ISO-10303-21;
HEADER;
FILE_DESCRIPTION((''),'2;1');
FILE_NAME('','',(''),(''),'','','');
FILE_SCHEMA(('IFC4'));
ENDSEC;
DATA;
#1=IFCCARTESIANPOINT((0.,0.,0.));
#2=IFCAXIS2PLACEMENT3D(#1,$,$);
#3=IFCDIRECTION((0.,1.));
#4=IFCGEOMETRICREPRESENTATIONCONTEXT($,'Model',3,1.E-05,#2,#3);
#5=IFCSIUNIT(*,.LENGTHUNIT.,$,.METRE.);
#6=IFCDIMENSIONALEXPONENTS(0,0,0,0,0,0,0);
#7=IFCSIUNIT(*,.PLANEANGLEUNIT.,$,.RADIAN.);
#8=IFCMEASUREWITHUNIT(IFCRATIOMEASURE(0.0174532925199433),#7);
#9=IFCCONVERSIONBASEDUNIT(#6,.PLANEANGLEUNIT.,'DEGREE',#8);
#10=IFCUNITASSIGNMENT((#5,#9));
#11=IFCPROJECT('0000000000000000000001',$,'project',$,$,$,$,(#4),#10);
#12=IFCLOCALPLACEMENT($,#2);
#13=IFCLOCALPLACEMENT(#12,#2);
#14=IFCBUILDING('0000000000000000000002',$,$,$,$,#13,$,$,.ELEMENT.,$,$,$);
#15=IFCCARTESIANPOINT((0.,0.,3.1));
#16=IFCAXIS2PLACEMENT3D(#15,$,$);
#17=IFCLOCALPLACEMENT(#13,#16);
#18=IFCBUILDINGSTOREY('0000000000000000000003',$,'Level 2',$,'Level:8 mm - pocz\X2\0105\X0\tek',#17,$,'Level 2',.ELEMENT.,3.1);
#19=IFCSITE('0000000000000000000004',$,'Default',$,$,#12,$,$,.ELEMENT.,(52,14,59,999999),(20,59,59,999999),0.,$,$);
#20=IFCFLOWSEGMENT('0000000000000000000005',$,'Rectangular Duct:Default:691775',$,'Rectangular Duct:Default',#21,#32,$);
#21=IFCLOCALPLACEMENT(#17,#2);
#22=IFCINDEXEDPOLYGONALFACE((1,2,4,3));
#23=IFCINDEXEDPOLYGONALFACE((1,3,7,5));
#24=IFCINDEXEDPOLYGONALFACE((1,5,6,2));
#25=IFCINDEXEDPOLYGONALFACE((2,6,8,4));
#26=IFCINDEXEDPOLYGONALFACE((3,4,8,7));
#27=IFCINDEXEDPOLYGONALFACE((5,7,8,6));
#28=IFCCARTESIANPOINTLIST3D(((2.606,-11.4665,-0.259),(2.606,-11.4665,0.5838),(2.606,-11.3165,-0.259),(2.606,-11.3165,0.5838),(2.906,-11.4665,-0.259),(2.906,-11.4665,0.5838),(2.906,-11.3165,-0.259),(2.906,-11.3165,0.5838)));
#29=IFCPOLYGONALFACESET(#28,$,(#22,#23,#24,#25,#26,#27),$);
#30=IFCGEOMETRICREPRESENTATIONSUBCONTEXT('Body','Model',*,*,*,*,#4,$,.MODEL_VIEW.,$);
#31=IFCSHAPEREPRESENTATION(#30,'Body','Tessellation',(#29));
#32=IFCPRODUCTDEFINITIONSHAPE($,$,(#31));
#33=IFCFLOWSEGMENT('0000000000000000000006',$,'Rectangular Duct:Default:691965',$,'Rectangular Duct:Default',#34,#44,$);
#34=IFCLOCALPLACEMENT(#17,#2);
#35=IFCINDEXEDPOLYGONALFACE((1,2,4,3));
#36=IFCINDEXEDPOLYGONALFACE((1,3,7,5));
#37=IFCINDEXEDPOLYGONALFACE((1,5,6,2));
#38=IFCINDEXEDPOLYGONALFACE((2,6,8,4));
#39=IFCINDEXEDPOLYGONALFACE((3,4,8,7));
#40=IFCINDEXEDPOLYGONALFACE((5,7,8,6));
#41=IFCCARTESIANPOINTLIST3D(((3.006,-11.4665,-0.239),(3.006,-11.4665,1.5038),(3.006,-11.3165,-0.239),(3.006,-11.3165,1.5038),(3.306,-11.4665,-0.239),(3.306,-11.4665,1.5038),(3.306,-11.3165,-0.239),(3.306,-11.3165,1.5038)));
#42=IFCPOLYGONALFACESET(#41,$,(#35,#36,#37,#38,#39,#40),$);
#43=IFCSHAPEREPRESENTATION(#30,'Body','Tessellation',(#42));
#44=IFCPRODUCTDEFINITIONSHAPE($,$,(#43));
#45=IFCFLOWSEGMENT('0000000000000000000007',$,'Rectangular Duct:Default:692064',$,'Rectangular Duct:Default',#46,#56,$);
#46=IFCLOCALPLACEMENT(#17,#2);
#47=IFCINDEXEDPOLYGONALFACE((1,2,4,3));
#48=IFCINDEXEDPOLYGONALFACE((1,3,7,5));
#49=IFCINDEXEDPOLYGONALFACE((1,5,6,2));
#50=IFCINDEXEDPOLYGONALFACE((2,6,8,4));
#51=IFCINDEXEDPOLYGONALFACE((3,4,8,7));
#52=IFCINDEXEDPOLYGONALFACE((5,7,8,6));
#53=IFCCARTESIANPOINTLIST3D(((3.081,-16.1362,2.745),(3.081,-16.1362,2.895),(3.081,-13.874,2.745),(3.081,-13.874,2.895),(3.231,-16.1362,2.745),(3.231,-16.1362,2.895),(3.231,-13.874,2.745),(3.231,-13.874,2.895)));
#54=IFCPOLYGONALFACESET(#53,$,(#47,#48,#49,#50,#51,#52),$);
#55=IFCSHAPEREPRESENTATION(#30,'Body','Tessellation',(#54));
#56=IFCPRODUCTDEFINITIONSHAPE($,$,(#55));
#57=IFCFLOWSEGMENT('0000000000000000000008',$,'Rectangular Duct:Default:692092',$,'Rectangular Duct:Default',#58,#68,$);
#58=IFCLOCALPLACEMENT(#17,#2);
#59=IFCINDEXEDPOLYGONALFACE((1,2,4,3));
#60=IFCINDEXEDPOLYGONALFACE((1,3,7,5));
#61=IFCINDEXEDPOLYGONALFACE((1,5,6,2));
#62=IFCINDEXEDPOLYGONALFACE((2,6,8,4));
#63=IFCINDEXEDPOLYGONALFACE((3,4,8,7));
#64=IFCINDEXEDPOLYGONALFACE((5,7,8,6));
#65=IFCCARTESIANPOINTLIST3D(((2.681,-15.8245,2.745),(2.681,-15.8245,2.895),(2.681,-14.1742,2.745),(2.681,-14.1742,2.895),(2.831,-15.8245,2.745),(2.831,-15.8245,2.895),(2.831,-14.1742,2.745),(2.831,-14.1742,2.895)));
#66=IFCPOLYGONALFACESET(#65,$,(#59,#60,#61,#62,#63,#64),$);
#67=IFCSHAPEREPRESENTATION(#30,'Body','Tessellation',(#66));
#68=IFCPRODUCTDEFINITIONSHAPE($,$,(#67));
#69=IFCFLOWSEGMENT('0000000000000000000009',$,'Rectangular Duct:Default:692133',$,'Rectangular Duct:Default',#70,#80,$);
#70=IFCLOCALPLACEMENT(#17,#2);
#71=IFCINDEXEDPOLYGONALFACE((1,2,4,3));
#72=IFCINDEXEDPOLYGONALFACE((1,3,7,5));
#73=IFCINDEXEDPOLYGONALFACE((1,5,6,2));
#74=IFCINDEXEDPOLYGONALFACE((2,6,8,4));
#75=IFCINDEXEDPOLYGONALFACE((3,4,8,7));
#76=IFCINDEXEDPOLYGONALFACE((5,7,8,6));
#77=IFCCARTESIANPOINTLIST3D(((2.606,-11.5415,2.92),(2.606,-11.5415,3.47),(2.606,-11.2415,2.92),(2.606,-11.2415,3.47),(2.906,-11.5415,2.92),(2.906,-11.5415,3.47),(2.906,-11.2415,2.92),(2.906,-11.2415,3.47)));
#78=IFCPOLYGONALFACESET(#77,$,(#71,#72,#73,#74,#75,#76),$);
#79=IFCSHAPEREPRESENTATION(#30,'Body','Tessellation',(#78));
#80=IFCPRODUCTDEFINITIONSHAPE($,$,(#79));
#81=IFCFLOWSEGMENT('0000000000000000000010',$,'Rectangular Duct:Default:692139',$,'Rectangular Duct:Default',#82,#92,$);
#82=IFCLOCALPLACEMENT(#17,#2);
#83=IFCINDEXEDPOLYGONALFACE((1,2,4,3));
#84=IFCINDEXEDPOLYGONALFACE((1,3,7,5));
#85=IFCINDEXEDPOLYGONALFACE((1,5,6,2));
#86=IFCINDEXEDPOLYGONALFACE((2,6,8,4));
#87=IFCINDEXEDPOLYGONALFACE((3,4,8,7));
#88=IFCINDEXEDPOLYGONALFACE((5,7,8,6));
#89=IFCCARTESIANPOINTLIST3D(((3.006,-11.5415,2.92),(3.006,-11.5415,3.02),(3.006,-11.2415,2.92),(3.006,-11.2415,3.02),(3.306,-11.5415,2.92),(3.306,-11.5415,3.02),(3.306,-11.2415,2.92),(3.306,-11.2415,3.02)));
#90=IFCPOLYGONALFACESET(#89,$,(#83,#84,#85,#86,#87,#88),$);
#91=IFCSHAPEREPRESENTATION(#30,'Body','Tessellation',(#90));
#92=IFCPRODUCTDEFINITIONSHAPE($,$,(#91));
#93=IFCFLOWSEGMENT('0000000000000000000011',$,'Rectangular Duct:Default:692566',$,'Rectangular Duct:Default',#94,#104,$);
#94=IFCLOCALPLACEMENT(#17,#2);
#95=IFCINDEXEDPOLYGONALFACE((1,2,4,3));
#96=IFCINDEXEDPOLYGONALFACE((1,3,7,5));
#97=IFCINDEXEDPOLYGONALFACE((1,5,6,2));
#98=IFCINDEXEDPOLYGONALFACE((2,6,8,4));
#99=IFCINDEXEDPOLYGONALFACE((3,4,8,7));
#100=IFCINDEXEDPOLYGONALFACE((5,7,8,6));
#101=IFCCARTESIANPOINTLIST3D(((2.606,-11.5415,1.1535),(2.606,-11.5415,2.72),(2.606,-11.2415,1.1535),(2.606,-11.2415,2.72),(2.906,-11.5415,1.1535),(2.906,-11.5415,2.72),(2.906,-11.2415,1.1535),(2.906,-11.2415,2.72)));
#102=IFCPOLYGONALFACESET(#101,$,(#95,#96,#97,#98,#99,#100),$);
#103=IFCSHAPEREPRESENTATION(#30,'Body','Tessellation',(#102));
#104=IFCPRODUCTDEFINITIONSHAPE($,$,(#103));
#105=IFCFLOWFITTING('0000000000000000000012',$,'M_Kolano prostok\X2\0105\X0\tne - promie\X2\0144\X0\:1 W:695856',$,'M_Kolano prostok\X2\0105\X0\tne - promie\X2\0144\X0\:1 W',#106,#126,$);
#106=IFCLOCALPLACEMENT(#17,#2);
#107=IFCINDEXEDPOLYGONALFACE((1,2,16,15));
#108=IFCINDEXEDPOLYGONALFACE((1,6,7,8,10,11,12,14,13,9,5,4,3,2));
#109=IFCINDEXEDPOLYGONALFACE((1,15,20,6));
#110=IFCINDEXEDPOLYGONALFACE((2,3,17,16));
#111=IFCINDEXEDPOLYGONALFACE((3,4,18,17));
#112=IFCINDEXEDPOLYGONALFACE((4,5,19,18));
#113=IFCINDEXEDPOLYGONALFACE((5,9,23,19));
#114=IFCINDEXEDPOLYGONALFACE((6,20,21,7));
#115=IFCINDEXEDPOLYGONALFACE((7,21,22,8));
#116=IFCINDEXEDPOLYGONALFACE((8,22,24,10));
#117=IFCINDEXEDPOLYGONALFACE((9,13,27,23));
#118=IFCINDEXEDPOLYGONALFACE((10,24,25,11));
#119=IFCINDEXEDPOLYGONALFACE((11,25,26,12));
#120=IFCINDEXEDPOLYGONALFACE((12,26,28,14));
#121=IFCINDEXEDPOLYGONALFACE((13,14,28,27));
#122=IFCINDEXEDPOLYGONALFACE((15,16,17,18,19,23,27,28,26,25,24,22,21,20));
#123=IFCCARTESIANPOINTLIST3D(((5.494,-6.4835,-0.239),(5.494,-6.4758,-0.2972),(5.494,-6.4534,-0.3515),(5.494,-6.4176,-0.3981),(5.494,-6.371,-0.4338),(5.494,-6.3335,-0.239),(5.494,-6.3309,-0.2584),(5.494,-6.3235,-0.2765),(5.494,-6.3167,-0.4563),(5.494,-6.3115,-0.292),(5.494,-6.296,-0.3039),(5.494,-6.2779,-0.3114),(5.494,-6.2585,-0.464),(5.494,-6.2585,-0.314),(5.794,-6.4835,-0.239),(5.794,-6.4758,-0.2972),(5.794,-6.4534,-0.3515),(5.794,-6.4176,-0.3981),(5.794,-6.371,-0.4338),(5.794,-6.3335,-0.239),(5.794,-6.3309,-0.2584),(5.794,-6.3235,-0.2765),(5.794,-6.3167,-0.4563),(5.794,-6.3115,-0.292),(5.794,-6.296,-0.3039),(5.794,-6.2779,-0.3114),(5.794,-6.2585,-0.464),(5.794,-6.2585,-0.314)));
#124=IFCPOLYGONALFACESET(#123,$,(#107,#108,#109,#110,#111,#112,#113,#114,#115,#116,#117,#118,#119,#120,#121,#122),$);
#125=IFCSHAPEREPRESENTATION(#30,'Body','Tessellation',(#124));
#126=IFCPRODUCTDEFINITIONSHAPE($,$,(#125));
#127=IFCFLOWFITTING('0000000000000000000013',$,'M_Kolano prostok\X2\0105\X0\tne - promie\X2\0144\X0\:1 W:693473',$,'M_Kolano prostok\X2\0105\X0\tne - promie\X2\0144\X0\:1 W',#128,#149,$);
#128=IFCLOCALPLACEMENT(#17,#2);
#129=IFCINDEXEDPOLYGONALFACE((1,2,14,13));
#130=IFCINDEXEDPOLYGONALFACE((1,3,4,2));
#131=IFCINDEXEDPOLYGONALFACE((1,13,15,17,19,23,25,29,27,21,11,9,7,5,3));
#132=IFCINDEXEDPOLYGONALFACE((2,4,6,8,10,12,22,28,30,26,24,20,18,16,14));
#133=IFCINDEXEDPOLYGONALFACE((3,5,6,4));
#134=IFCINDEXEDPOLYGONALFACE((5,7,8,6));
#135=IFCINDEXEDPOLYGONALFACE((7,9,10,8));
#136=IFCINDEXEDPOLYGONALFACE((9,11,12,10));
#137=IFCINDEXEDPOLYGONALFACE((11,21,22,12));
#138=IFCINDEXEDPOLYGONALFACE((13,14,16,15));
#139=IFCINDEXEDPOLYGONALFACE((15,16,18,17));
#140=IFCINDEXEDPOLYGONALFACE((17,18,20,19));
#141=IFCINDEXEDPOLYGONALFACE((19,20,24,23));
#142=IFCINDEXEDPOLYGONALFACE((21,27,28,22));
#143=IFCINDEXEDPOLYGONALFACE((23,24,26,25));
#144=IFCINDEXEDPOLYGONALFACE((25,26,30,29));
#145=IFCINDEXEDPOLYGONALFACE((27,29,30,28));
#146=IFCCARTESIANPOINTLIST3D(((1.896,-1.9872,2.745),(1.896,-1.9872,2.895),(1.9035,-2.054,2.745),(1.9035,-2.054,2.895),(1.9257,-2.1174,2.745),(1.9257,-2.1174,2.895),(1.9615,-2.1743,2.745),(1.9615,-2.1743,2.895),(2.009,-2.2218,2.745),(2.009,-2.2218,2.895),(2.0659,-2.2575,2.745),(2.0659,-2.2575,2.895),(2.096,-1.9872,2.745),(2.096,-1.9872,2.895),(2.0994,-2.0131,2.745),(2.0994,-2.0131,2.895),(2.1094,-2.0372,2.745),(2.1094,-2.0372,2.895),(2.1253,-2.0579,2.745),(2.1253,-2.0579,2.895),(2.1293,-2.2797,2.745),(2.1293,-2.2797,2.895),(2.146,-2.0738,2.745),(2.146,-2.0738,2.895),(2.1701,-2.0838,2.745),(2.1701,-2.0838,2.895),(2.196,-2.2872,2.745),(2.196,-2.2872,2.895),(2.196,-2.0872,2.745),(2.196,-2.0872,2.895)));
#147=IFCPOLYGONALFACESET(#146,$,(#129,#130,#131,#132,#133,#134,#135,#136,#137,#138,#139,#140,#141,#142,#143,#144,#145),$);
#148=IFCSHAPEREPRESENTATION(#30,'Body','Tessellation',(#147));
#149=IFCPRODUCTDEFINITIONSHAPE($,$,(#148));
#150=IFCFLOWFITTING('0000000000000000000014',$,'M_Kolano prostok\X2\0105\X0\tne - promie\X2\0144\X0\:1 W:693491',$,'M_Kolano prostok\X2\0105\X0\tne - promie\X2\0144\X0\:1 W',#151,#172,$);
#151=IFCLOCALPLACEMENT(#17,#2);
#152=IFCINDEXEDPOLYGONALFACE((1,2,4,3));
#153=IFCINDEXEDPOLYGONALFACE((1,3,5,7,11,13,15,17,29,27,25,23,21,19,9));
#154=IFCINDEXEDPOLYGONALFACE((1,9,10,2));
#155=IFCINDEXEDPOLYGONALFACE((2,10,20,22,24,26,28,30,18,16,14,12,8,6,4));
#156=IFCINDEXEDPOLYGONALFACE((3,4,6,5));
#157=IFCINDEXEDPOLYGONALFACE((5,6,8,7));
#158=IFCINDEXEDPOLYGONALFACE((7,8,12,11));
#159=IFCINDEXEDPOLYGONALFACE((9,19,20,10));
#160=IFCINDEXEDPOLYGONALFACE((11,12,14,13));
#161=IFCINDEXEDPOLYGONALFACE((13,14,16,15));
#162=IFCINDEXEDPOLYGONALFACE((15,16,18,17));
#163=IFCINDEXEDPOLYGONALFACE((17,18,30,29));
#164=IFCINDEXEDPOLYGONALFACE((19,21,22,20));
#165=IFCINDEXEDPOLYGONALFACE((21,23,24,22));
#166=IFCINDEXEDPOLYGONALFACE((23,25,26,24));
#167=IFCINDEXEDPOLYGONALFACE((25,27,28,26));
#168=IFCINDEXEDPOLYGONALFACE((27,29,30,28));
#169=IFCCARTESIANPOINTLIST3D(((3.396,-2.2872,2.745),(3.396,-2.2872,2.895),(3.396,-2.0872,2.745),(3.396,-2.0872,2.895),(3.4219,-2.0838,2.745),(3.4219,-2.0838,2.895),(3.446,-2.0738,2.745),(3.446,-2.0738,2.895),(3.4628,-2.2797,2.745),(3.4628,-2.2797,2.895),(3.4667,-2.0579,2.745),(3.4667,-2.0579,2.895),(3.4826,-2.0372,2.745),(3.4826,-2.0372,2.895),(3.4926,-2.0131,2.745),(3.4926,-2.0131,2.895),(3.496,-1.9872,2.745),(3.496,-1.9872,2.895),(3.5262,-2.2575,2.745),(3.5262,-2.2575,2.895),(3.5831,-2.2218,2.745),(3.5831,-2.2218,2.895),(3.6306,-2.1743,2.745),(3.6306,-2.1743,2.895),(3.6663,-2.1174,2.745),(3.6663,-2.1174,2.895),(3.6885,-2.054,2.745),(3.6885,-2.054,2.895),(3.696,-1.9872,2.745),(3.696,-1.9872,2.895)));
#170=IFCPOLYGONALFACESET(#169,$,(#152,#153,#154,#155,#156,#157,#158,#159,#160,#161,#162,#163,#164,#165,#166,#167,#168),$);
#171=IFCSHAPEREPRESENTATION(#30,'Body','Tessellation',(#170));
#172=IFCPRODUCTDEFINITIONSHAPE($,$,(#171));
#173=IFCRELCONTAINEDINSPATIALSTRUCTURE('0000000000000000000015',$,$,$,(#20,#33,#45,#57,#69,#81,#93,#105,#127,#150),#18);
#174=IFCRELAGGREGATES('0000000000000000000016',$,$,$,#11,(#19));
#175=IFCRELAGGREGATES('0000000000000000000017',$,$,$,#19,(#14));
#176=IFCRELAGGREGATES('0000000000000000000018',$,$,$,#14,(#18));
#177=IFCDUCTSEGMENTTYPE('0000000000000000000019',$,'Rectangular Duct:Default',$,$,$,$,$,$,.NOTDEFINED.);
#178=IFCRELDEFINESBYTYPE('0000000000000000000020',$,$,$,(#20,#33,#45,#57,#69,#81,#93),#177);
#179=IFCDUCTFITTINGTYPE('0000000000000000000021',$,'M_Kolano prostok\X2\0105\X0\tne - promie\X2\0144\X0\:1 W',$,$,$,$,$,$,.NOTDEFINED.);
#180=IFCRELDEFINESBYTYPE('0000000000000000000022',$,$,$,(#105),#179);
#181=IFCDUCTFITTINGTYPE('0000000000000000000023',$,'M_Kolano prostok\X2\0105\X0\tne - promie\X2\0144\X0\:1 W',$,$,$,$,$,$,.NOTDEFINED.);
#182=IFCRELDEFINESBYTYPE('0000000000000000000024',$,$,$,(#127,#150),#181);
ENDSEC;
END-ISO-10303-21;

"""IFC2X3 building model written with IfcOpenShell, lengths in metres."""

from ifc_helpers import new_model, entity, si_unit, converted_unit, direction, frame, frame_2d, origin, origin_2d_with_axis, place, context, subcontext, project, spatial, polyline, circle_curve, parameter, trimmed, segment, composite_curve, rectangle, outline, extrude, source, transform, mapped, type_object, type_shapes, element, save


model = new_model("IFC2X3")

# Units and contexts
model_context = context("Model", 3, precision=1e-05, world=origin(), true_north=direction((0.0, 1.0)))
body_context = subcontext(model_context, "Body", "Model", "MODEL_VIEW")
ifc_project = project(units=[si_unit("LENGTHUNIT", "METRE"), converted_unit("PLANEANGLEUNIT", "DEGREE", entity("IfcRatioMeasure", 0.0174532925199433), si_unit("PLANEANGLEUNIT", "RADIAN"), dimensions=[0, 0, 0, 0, 0, 0, 0])], contexts=[model_context])

# Site, building, storey
site_placement = place(None, origin())
site = spatial("IfcSite", under=ifc_project, at=site_placement, Name="Default", CompositionType="ELEMENT", RefLatitude=(52, 14, 59, 999999), RefLongitude=(20, 59, 59, 999999), RefElevation=0.0)
building_placement = place(site_placement, origin())
building = spatial("IfcBuilding", under=site, at=building_placement, CompositionType="ELEMENT")
storey_placement = place(building_placement, frame((0.0, 0.0, 3.1)))
storey = spatial("IfcBuildingStorey", under=building, at=storey_placement, Name="Level 2", ObjectType="Level:8 mm - początek", LongName="Level 2", CompositionType="ELEMENT", Elevation=3.1)

# Flow segments
duct_segment_type = type_object("IfcDuctSegmentType", Name="Rectangular Duct:Default", PredefinedType="NOTDEFINED")
flow_segment_1_placement = place(storey_placement, origin())
element("IfcFlowSegment", 1, at=flow_segment_1_placement, inside=storey, type_object=duct_segment_type, Name="Rectangular Duct:Default:691775", ObjectType="Rectangular Duct:Default", context=body_context, shape_type="SweptSolid", body=[
    extrude(rectangle(XDim=0.15, YDim=0.3, at=origin_2d_with_axis()), frame((2.756, -11.3915, -0.259), z_axis=(0.0, 0.0, 1.0), x_axis=(0.0, 1.0, 0.0)), (0.0, 0.0, 1.0), 0.8428),
])
flow_segment_2_placement = place(storey_placement, origin())
element("IfcFlowSegment", 2, at=flow_segment_2_placement, inside=storey, type_object=duct_segment_type, Name="Rectangular Duct:Default:691965", ObjectType="Rectangular Duct:Default", context=body_context, shape_type="SweptSolid", body=[
    extrude(rectangle(XDim=0.15, YDim=0.3, at=origin_2d_with_axis()), frame((3.156, -11.3915, -0.239), z_axis=(0.0, 0.0, 1.0), x_axis=(0.0, 1.0, 0.0)), (0.0, 0.0, 1.0), 1.7428),
])
flow_segment_3_placement = place(storey_placement, origin())
element("IfcFlowSegment", 3, at=flow_segment_3_placement, inside=storey, type_object=duct_segment_type, Name="Rectangular Duct:Default:692064", ObjectType="Rectangular Duct:Default", context=body_context, shape_type="SweptSolid", body=[
    extrude(rectangle(XDim=2.2622, YDim=0.15, at=frame_2d((0.0, 0.0), x_axis=(1.0, 0.0))), frame((3.156, -15.0051, 2.745), z_axis=(0.0, 0.0, 1.0), x_axis=(0.0, -1.0, 0.0)), (0.0, 0.0, 1.0), 0.15),
])
flow_segment_4_placement = place(storey_placement, origin())
element("IfcFlowSegment", 4, at=flow_segment_4_placement, inside=storey, type_object=duct_segment_type, Name="Rectangular Duct:Default:692092", ObjectType="Rectangular Duct:Default", context=body_context, shape_type="SweptSolid", body=[
    extrude(rectangle(XDim=1.6504, YDim=0.15, at=frame_2d((0.0, 0.0), x_axis=(1.0, 0.0))), frame((2.756, -14.9994, 2.745), z_axis=(0.0, 0.0, 1.0), x_axis=(0.0, -1.0, 0.0)), (0.0, 0.0, 1.0), 0.15),
])
flow_segment_5_placement = place(storey_placement, origin())
element("IfcFlowSegment", 5, at=flow_segment_5_placement, inside=storey, type_object=duct_segment_type, Name="Rectangular Duct:Default:692133", ObjectType="Rectangular Duct:Default", context=body_context, shape_type="SweptSolid", body=[
    extrude(rectangle(XDim=0.3, YDim=0.3, at=frame_2d((0.0, 0.0), x_axis=(1.0, 0.0))), frame((2.756, -11.3915, 2.92), z_axis=(0.0, 0.0, 1.0), x_axis=(0.0, -1.0, 0.0)), (0.0, 0.0, 1.0), 0.55),
])
flow_segment_6_placement = place(storey_placement, origin())
element("IfcFlowSegment", 6, at=flow_segment_6_placement, inside=storey, type_object=duct_segment_type, Name="Rectangular Duct:Default:692139", ObjectType="Rectangular Duct:Default", context=body_context, shape_type="SweptSolid", body=[
    extrude(rectangle(XDim=0.3, YDim=0.3, at=origin_2d_with_axis()), frame((3.156, -11.3915, 2.92), z_axis=(0.0, 0.0, 1.0), x_axis=(0.0, -1.0, 0.0)), (0.0, 0.0, 1.0), 0.1),
])
flow_segment_7_placement = place(storey_placement, origin())
element("IfcFlowSegment", 7, at=flow_segment_7_placement, inside=storey, type_object=duct_segment_type, Name="Rectangular Duct:Default:692566", ObjectType="Rectangular Duct:Default", context=body_context, shape_type="SweptSolid", body=[
    extrude(rectangle(XDim=0.3, YDim=0.3, at=frame_2d((0.0, 0.0), x_axis=(1.0, 0.0))), frame((2.756, -11.3915, 1.1535), z_axis=(0.0, 0.0, 1.0), x_axis=(0.0, 1.0, 0.0)), (0.0, 0.0, 1.0), 1.5665),
])

# Flow fittings
duct_fitting_type_1 = type_object("IfcDuctFittingType", Name="M_Kolano prostokątne - promień:1 W", PredefinedType="NOTDEFINED")
shared_shape_1 = source(origin(), body_context, "Body", "SweptSolid", [
    extrude(outline(composite_curve([segment(polyline([(-0.15, -0.075), (0.0, -0.075)]), True, "CONTINUOUS"), segment(trimmed(circle_curve(frame_2d((0.075, -0.075), x_axis=(0.0, 1.0)), 0.075), [parameter(0.0)], [parameter(90.0)], True, "PARAMETER"), False, "CONTINUOUS"), segment(polyline([(0.075, 0.0), (0.075, 0.15)]), True, "CONTINUOUS"), segment(trimmed(circle_curve(frame_2d((0.075, -0.075), x_axis=(0.0, 1.0)), 0.225), [parameter(0.0)], [parameter(90.0)], True, "PARAMETER"), True, "CONTINUOUS")], self_intersect=False)), frame((-0.075, 0.075, -0.15), z_axis=(0.0, 0.0, 1.0), x_axis=(-1.0, 0.0, 0.0)), (0.0, 0.0, 1.0), 0.3),
])
type_shapes(duct_fitting_type_1, [shared_shape_1])
flow_fitting_1_placement = place(storey_placement, frame((5.644, -6.4085, -0.389), z_axis=(1.0, 0.0, 0.0), x_axis=(0.0, 0.0, -1.0)))
element("IfcFlowFitting", 8, at=flow_fitting_1_placement, inside=storey, type_object=duct_fitting_type_1, Name="M_Kolano prostokątne - promień:1 W:695856", ObjectType="M_Kolano prostokątne - promień:1 W", context=body_context, shape_type="MappedRepresentation", body=[
    mapped(shared_shape_1, transform((0.0, 0.0, 0.0), scale=1.0)),
])
duct_fitting_type_2 = type_object("IfcDuctFittingType", Name="M_Kolano prostokątne - promień:1 W", PredefinedType="NOTDEFINED")
shared_shape_2 = source(origin(), body_context, "Body", "SweptSolid", [
    extrude(outline(composite_curve([segment(polyline([(-0.2, -0.1), (0.0, -0.1)]), True, "CONTINUOUS"), segment(trimmed(circle_curve(frame_2d((0.1, -0.1), x_axis=(0.0, 1.0)), 0.1), [parameter(0.0)], [parameter(90.0)], True, "PARAMETER"), False, "CONTINUOUS"), segment(polyline([(0.1, 0.0), (0.1, 0.2)]), True, "CONTINUOUS"), segment(trimmed(circle_curve(frame_2d((0.1, -0.1), x_axis=(0.0, 1.0)), 0.3), [parameter(0.0)], [parameter(90.0)], True, "PARAMETER"), True, "CONTINUOUS")], self_intersect=False)), frame((-0.1, 0.1, -0.075), z_axis=(0.0, 0.0, 1.0), x_axis=(-1.0, 0.0, 0.0)), (0.0, 0.0, 1.0), 0.15),
])
type_shapes(duct_fitting_type_2, [shared_shape_2])
flow_fitting_2_placement = place(storey_placement, frame((1.996, -2.1872, 2.82), z_axis=(0.0, 0.0, 1.0), x_axis=(0.0, -1.0, 0.0)))
element("IfcFlowFitting", 9, at=flow_fitting_2_placement, inside=storey, type_object=duct_fitting_type_2, Name="M_Kolano prostokątne - promień:1 W:693473", ObjectType="M_Kolano prostokątne - promień:1 W", context=body_context, shape_type="MappedRepresentation", body=[
    mapped(shared_shape_2, transform((0.0, 0.0, 0.0), scale=1.0)),
])
flow_fitting_3_placement = place(storey_placement, frame((3.596, -2.1872, 2.82)))
element("IfcFlowFitting", 10, at=flow_fitting_3_placement, inside=storey, type_object=duct_fitting_type_2, Name="M_Kolano prostokątne - promień:1 W:693491", ObjectType="M_Kolano prostokątne - promień:1 W", context=body_context, shape_type="MappedRepresentation", body=[
    mapped(shared_shape_2, transform((0.0, 0.0, 0.0), scale=1.0)),
])

save(model, "model.ifc")
